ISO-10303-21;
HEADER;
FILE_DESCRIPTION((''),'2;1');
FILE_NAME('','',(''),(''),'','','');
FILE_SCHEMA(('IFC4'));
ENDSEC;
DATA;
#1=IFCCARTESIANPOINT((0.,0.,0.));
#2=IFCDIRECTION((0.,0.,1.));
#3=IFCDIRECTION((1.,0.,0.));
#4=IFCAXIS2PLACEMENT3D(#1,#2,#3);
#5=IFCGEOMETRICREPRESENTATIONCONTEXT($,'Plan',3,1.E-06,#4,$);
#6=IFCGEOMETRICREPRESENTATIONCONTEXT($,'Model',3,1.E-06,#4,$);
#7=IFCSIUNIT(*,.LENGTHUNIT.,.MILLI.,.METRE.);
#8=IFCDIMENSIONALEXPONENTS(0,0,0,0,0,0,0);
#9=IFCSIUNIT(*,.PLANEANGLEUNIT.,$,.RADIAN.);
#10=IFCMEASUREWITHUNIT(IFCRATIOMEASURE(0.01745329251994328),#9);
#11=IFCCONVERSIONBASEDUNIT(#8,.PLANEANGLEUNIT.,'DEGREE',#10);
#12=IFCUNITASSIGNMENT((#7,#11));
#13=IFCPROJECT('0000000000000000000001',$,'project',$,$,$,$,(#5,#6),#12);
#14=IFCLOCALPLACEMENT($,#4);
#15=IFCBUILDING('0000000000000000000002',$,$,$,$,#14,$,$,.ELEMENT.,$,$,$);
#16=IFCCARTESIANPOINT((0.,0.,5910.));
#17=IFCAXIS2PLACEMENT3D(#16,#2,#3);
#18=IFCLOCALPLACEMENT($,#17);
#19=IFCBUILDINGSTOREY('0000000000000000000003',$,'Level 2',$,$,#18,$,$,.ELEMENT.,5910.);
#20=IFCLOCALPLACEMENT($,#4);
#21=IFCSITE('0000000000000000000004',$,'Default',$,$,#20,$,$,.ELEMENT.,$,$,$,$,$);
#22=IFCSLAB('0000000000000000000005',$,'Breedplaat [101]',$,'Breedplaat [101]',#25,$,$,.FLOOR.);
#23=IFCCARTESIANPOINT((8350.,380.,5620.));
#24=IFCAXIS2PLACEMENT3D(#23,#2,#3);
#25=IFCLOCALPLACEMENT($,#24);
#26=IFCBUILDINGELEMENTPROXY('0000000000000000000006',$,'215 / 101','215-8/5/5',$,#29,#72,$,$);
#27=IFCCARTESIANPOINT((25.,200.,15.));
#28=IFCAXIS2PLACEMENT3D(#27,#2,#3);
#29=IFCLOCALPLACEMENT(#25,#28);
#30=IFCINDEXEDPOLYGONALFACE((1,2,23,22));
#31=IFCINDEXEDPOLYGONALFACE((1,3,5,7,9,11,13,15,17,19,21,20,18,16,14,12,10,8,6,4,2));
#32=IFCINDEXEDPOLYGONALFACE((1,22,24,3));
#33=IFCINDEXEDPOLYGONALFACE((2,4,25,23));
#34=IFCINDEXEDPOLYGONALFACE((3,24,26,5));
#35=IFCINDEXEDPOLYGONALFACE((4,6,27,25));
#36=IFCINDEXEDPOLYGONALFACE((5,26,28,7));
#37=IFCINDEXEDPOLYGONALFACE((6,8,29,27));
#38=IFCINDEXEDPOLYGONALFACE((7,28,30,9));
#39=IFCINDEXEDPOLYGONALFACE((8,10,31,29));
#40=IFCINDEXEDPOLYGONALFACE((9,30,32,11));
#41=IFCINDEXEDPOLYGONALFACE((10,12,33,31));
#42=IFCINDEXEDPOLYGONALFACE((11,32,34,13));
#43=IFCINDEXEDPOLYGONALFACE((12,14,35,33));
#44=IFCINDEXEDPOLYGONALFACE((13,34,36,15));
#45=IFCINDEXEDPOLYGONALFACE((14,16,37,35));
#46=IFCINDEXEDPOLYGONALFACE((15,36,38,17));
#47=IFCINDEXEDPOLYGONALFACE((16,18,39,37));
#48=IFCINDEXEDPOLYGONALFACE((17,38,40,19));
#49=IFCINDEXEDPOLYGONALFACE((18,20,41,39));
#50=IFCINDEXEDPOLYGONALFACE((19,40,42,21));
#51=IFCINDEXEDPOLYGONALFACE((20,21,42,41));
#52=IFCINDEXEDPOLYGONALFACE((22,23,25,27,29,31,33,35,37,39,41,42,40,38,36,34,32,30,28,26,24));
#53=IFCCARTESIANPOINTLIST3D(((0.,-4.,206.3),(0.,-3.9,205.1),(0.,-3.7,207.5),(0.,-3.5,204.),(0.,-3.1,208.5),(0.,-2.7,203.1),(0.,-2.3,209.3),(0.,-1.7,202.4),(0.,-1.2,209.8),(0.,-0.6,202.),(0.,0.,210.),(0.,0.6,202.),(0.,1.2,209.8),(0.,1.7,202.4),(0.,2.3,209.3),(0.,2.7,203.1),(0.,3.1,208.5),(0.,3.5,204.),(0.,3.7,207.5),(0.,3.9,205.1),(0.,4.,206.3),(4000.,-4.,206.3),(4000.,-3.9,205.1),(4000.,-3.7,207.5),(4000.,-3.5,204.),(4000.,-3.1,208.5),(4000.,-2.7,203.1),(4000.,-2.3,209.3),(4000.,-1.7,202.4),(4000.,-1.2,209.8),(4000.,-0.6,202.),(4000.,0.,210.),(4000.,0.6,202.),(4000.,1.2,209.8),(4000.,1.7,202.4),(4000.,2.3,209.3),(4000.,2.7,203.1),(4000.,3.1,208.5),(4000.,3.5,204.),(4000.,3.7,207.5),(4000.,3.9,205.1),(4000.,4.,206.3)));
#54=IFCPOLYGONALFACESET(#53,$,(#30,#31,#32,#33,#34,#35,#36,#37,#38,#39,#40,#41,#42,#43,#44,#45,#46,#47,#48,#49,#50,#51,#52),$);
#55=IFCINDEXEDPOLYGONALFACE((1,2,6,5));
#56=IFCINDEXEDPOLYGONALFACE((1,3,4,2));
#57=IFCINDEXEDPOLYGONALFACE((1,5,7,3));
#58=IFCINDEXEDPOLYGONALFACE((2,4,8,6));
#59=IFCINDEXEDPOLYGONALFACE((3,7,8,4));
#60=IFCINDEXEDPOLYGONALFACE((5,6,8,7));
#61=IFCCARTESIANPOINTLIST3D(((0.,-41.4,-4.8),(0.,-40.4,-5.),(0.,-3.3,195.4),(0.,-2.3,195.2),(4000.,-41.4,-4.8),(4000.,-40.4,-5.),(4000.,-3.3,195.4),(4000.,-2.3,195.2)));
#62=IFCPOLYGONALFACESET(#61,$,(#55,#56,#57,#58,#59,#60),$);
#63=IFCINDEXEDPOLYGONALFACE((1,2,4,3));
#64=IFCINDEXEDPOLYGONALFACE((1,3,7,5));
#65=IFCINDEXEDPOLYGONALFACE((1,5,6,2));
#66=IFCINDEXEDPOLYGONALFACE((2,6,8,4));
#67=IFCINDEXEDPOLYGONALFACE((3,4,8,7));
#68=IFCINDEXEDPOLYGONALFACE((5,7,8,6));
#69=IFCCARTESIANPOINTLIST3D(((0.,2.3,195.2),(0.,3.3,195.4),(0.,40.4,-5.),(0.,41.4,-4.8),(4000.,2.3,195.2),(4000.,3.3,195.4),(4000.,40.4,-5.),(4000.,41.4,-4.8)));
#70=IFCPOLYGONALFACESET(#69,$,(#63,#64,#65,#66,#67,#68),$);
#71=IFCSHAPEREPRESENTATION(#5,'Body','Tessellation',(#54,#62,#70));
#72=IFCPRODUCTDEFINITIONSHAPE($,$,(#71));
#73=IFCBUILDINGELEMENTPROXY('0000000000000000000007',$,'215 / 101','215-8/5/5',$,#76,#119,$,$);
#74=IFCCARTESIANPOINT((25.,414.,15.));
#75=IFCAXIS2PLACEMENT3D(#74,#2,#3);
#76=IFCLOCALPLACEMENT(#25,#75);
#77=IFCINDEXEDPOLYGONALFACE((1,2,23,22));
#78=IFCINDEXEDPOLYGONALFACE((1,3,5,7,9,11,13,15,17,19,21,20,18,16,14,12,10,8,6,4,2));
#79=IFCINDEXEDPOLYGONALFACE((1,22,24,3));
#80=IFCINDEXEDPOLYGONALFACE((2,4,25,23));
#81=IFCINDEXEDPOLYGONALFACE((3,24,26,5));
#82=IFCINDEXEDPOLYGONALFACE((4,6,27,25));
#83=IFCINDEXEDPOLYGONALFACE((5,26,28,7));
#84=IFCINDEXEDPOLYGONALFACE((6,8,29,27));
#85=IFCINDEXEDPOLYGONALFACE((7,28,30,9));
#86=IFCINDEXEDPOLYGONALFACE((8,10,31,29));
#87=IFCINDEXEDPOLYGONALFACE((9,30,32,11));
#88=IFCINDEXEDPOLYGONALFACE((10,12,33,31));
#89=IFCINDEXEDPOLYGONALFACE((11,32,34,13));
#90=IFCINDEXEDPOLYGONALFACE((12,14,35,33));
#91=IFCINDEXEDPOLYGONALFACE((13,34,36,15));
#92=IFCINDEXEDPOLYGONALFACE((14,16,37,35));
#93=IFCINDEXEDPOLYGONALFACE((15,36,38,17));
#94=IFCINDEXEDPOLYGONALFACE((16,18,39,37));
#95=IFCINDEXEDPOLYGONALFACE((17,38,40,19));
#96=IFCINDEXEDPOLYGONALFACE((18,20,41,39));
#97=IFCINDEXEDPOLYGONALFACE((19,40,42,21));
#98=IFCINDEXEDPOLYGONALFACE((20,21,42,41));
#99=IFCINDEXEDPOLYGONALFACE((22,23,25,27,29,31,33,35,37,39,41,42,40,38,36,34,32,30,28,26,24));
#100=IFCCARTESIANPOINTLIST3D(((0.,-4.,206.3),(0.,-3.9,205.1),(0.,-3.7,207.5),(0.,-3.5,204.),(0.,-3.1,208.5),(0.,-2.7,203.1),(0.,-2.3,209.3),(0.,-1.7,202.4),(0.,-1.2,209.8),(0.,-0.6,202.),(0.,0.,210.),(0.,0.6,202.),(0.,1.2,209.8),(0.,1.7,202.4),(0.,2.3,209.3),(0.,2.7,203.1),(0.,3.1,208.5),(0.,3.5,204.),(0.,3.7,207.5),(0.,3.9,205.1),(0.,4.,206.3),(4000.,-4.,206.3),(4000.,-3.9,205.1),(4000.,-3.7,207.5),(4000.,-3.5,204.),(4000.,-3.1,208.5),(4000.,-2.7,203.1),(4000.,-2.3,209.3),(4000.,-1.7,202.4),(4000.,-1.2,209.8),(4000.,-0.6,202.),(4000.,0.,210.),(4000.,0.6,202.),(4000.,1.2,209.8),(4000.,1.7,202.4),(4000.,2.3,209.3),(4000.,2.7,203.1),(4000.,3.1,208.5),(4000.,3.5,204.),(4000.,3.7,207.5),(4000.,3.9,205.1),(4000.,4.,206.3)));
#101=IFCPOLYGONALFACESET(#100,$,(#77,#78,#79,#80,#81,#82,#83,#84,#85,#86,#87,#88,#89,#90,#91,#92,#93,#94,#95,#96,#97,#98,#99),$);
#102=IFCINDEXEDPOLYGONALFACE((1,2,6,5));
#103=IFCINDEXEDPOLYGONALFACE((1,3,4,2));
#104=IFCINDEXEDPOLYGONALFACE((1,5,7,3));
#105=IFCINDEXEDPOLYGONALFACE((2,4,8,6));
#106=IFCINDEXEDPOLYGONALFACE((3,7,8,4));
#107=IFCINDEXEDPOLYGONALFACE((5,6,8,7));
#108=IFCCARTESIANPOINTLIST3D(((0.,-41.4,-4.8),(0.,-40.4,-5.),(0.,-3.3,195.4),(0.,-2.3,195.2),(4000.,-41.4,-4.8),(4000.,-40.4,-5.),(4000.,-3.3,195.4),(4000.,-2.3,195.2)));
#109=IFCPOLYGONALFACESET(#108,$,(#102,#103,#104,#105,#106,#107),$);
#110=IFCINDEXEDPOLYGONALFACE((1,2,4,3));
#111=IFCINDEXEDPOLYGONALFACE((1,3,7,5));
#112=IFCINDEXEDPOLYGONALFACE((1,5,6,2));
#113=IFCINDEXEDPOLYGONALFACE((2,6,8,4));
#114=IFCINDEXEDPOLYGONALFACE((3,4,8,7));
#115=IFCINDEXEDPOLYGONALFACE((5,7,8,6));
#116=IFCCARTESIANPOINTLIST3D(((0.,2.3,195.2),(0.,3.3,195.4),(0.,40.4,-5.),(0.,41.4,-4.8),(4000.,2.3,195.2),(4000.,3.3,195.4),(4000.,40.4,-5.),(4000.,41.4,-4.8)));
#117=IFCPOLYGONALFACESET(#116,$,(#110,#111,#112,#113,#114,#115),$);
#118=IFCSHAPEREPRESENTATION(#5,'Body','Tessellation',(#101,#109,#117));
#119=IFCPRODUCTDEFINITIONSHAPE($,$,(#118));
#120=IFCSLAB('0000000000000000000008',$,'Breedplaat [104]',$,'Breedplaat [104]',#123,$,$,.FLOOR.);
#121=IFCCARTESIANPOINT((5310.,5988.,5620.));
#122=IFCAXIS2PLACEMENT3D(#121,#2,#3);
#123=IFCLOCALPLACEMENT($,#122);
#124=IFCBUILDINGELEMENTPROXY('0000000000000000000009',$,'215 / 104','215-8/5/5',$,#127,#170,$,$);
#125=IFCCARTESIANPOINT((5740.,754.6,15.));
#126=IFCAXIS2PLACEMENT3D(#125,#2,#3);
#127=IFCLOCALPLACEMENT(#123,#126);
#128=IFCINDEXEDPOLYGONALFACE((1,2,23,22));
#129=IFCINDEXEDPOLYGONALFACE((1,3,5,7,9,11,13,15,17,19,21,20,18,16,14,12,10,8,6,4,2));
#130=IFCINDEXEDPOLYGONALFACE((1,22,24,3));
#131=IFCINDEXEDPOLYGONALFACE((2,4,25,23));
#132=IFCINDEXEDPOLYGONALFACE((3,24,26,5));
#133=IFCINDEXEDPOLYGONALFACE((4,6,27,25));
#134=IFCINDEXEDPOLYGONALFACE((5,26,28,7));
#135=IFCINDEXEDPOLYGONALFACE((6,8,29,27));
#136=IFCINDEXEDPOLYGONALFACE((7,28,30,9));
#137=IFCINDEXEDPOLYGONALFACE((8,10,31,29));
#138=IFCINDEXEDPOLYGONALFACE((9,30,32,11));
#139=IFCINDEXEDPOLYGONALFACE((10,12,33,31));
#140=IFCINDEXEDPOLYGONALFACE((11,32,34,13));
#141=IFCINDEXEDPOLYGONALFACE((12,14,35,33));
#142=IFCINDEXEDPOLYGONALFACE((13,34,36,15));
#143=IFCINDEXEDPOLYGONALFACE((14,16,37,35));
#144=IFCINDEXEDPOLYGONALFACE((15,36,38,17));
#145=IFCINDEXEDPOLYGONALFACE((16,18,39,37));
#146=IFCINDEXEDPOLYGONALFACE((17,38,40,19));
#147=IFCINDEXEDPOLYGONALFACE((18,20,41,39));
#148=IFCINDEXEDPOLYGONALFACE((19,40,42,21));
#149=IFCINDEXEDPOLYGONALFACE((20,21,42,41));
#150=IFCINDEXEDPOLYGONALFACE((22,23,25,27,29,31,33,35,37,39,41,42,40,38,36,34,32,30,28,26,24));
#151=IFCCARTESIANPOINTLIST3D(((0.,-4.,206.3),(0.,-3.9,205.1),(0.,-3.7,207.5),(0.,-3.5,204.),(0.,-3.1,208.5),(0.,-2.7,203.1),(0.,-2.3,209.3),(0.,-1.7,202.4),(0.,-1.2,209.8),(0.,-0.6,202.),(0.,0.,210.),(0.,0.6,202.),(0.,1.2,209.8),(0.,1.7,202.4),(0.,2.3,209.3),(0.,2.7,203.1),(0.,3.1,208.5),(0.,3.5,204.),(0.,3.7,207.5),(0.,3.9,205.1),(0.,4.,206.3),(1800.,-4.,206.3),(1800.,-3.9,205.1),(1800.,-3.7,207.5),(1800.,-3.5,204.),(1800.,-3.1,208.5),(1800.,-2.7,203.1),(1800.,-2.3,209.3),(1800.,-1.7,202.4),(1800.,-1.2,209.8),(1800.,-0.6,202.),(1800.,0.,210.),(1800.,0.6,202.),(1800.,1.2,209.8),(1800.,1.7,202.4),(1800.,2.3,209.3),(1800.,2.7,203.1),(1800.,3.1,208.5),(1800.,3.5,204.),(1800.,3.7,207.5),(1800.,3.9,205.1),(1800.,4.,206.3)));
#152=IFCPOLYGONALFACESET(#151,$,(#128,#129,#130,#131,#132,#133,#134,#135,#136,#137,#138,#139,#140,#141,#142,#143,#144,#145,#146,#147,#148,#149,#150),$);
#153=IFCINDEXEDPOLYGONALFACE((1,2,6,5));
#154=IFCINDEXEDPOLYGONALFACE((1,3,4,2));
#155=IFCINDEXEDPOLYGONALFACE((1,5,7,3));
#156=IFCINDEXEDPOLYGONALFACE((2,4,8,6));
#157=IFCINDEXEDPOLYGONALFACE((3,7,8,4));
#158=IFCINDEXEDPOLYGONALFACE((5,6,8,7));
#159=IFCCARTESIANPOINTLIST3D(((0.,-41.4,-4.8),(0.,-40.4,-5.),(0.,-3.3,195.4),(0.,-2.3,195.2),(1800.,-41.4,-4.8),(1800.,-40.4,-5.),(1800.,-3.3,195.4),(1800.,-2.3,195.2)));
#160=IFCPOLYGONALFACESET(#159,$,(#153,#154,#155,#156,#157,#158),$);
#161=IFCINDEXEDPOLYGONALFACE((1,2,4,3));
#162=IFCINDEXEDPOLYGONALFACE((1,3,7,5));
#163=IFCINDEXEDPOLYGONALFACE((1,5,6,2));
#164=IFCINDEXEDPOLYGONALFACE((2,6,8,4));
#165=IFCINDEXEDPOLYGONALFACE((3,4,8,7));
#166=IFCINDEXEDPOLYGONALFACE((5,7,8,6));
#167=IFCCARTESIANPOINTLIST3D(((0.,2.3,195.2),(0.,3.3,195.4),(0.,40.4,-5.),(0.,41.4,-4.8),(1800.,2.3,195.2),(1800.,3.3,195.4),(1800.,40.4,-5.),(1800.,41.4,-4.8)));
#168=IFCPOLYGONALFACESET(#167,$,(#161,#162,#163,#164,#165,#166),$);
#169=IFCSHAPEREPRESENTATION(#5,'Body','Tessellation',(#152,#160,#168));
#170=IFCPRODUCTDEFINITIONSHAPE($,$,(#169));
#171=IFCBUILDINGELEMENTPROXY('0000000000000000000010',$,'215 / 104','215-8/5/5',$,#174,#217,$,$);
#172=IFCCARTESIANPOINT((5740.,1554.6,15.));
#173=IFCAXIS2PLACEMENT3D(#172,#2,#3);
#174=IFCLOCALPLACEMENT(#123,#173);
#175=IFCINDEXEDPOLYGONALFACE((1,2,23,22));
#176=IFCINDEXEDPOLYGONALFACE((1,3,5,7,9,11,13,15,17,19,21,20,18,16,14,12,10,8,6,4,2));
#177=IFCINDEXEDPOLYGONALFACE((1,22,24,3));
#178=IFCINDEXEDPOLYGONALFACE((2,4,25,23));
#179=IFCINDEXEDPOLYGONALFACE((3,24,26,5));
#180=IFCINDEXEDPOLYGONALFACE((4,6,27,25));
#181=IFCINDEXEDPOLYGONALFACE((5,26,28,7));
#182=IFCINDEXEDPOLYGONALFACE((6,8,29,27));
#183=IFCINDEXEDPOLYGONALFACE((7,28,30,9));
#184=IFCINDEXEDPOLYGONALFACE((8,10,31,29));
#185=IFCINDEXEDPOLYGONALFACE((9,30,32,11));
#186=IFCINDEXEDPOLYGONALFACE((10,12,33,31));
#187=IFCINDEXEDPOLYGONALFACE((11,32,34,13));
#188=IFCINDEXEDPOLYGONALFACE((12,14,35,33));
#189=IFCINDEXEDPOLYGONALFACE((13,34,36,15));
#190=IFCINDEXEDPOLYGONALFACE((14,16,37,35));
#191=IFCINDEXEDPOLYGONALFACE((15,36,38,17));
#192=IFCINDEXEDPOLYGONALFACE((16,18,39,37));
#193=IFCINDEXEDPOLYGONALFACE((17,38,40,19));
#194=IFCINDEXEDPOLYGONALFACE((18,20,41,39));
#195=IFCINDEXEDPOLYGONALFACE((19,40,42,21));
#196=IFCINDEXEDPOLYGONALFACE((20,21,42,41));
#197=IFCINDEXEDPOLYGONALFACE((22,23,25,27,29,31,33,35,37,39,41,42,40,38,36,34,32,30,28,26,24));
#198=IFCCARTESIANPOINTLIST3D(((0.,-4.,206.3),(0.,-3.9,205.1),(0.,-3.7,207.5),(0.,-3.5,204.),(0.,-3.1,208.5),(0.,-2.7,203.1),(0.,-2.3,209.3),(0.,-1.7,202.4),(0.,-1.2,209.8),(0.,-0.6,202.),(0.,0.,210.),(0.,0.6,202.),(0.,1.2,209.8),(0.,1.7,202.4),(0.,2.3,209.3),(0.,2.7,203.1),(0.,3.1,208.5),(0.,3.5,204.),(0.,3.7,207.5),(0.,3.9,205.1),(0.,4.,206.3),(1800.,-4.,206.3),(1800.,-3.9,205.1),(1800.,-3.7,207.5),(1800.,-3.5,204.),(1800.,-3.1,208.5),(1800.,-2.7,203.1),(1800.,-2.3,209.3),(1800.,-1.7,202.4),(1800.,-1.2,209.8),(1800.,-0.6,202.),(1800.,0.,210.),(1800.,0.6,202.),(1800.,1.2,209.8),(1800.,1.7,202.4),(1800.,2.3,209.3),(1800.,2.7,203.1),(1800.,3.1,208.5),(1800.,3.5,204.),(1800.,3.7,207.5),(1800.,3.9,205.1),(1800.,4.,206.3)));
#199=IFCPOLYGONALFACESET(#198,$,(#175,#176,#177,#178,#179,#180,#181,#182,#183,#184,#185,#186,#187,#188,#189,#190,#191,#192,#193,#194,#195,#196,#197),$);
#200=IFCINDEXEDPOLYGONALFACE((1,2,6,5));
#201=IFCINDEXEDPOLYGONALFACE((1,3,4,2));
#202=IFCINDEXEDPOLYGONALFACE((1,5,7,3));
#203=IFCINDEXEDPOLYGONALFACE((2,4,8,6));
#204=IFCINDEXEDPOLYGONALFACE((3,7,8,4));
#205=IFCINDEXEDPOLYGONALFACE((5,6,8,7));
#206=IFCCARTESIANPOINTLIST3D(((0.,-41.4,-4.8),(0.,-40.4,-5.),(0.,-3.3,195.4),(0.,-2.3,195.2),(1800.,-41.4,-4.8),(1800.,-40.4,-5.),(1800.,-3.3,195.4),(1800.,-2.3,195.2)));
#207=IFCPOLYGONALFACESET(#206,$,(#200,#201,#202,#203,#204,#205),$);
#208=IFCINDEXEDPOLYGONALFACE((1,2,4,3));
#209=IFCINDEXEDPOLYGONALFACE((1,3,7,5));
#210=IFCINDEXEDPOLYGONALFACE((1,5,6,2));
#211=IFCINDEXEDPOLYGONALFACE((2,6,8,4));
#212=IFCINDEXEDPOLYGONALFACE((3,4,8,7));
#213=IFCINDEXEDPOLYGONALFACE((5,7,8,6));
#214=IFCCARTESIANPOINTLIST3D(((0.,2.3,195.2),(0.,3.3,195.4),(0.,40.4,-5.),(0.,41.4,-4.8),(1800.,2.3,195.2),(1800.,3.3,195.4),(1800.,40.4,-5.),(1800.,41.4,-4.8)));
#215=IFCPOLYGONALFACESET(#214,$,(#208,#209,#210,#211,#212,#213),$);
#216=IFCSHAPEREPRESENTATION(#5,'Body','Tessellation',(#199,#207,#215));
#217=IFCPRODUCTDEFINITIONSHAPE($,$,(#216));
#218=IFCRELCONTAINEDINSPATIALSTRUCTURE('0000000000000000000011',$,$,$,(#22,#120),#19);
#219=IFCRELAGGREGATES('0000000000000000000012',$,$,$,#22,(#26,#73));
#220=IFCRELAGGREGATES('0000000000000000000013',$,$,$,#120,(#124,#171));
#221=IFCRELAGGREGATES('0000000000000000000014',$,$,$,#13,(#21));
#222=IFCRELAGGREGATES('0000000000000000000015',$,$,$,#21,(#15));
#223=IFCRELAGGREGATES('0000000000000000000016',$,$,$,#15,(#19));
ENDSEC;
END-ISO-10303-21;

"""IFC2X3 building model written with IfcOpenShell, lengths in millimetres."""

from ifc_helpers import new_model, entity, si_unit, converted_unit, frame, origin_with_axes, origin_2d_with_axis, place, context, project, spatial, rectangle, circle, extrude, element, aggregate, save


model = new_model("IFC2X3")

# Units and contexts
plan_context = context("Plan", 3, precision=1e-06, world=origin_with_axes())
model_context = context("Model", 3, precision=1e-06, world=origin_with_axes())
ifc_project = project(units=[si_unit("LENGTHUNIT", "METRE", prefix="MILLI"), converted_unit("PLANEANGLEUNIT", "DEGREE", entity("IfcRatioMeasure", 0.01745329251994328), si_unit("PLANEANGLEUNIT", "RADIAN"), dimensions=[0, 0, 0, 0, 0, 0, 0])], contexts=[plan_context, model_context])

# Site, building, storey
site_placement = place(None, origin_with_axes())
site = spatial("IfcSite", under=ifc_project, at=site_placement, Name="Default", CompositionType="ELEMENT")
building_placement = place(None, origin_with_axes())
building = spatial("IfcBuilding", under=site, at=building_placement, CompositionType="ELEMENT")
storey_placement = place(None, frame((0.0, 0.0, 5910.0), z_axis=(0.0, 0.0, 1.0), x_axis=(1.0, 0.0, 0.0)))
storey = spatial("IfcBuildingStorey", under=building, at=storey_placement, Name="Level 2", CompositionType="ELEMENT", Elevation=5910.0)

# Slab, building element proxies
slab_1_placement = place(None, frame((8350.0, 380.0, 5620.0), z_axis=(0.0, 0.0, 1.0), x_axis=(1.0, 0.0, 0.0)))
slab_1 = element("IfcSlab", 1, at=slab_1_placement, inside=storey, Name="Breedplaat [101]", ObjectType="Breedplaat [101]", PredefinedType="FLOOR")
proxy_1_placement = place(slab_1_placement, frame((25.0, 200.0, 15.0), z_axis=(0.0, 0.0, 1.0), x_axis=(1.0, 0.0, 0.0)))
proxy_1 = element("IfcBuildingElementProxy", 2, at=proxy_1_placement, Name="215 / 101", Description="215-8/5/5", context=plan_context, shape_type="SweptSolid", body=[
    extrude(circle(Radius=4.0, at=origin_2d_with_axis()), frame((0.0, 0.0, 206.0), z_axis=(1.0, 0.0, 0.0), x_axis=(0.0, 0.0, 1.0)), (0.0, 0.0, 1.0), 4000.0),
    extrude(rectangle(XDim=203.8, YDim=1.0, at=origin_2d_with_axis()), frame((0.0, -21.9, 95.2), z_axis=(1.0, 0.0, 0.0), x_axis=(0.0, 0.187112, 0.982339)), (0.0, 0.0, 1.0), 4000.0),
    extrude(rectangle(XDim=203.8, YDim=1.0, at=origin_2d_with_axis()), frame((0.0, 21.9, 95.2), z_axis=(1.0, 0.0, 0.0), x_axis=(0.0, -0.187112, 0.982339)), (0.0, 0.0, 1.0), 4000.0),
])
proxy_2_placement = place(slab_1_placement, frame((25.0, 414.0, 15.0), z_axis=(0.0, 0.0, 1.0), x_axis=(1.0, 0.0, 0.0)))
proxy_2 = element("IfcBuildingElementProxy", 3, at=proxy_2_placement, Name="215 / 101", Description="215-8/5/5", context=plan_context, shape_type="SweptSolid", body=[
    extrude(circle(Radius=4.0, at=origin_2d_with_axis()), frame((0.0, 0.0, 206.0), z_axis=(1.0, 0.0, 0.0), x_axis=(0.0, 0.0, 1.0)), (0.0, 0.0, 1.0), 4000.0),
    extrude(rectangle(XDim=203.8, YDim=1.0, at=origin_2d_with_axis()), frame((0.0, -21.9, 95.2), z_axis=(1.0, 0.0, 0.0), x_axis=(0.0, 0.187112, 0.982339)), (0.0, 0.0, 1.0), 4000.0),
    extrude(rectangle(XDim=203.8, YDim=1.0, at=origin_2d_with_axis()), frame((0.0, 21.9, 95.2), z_axis=(1.0, 0.0, 0.0), x_axis=(0.0, -0.187112, 0.982339)), (0.0, 0.0, 1.0), 4000.0),
])
aggregate(slab_1, [proxy_1, proxy_2])

# Slab, building element proxies
slab_2_placement = place(None, frame((5310.0, 5988.0, 5620.0), z_axis=(0.0, 0.0, 1.0), x_axis=(1.0, 0.0, 0.0)))
slab_2 = element("IfcSlab", 4, at=slab_2_placement, inside=storey, Name="Breedplaat [104]", ObjectType="Breedplaat [104]", PredefinedType="FLOOR")
proxy_3_placement = place(slab_2_placement, frame((5740.0, 754.6, 15.0), z_axis=(0.0, 0.0, 1.0), x_axis=(1.0, 0.0, 0.0)))
proxy_3 = element("IfcBuildingElementProxy", 5, at=proxy_3_placement, Name="215 / 104", Description="215-8/5/5", context=plan_context, shape_type="SweptSolid", body=[
    extrude(circle(Radius=4.0, at=origin_2d_with_axis()), frame((0.0, 0.0, 206.0), z_axis=(1.0, 0.0, 0.0), x_axis=(0.0, 0.0, 1.0)), (0.0, 0.0, 1.0), 1800.0),
    extrude(rectangle(XDim=203.8, YDim=1.0, at=origin_2d_with_axis()), frame((0.0, -21.9, 95.2), z_axis=(1.0, 0.0, 0.0), x_axis=(0.0, 0.187112, 0.982339)), (0.0, 0.0, 1.0), 1800.0),
    extrude(rectangle(XDim=203.8, YDim=1.0, at=origin_2d_with_axis()), frame((0.0, 21.9, 95.2), z_axis=(1.0, 0.0, 0.0), x_axis=(0.0, -0.187112, 0.982339)), (0.0, 0.0, 1.0), 1800.0),
])
proxy_4_placement = place(slab_2_placement, frame((5740.0, 1554.6, 15.0), z_axis=(0.0, 0.0, 1.0), x_axis=(1.0, 0.0, 0.0)))
proxy_4 = element("IfcBuildingElementProxy", 6, at=proxy_4_placement, Name="215 / 104", Description="215-8/5/5", context=plan_context, shape_type="SweptSolid", body=[
    extrude(circle(Radius=4.0, at=origin_2d_with_axis()), frame((0.0, 0.0, 206.0), z_axis=(1.0, 0.0, 0.0), x_axis=(0.0, 0.0, 1.0)), (0.0, 0.0, 1.0), 1800.0),
    extrude(rectangle(XDim=203.8, YDim=1.0, at=origin_2d_with_axis()), frame((0.0, -21.9, 95.2), z_axis=(1.0, 0.0, 0.0), x_axis=(0.0, 0.187112, 0.982339)), (0.0, 0.0, 1.0), 1800.0),
    extrude(rectangle(XDim=203.8, YDim=1.0, at=origin_2d_with_axis()), frame((0.0, 21.9, 95.2), z_axis=(1.0, 0.0, 0.0), x_axis=(0.0, -0.187112, 0.982339)), (0.0, 0.0, 1.0), 1800.0),
])
aggregate(slab_2, [proxy_3, proxy_4])

save(model, "model.ifc")
